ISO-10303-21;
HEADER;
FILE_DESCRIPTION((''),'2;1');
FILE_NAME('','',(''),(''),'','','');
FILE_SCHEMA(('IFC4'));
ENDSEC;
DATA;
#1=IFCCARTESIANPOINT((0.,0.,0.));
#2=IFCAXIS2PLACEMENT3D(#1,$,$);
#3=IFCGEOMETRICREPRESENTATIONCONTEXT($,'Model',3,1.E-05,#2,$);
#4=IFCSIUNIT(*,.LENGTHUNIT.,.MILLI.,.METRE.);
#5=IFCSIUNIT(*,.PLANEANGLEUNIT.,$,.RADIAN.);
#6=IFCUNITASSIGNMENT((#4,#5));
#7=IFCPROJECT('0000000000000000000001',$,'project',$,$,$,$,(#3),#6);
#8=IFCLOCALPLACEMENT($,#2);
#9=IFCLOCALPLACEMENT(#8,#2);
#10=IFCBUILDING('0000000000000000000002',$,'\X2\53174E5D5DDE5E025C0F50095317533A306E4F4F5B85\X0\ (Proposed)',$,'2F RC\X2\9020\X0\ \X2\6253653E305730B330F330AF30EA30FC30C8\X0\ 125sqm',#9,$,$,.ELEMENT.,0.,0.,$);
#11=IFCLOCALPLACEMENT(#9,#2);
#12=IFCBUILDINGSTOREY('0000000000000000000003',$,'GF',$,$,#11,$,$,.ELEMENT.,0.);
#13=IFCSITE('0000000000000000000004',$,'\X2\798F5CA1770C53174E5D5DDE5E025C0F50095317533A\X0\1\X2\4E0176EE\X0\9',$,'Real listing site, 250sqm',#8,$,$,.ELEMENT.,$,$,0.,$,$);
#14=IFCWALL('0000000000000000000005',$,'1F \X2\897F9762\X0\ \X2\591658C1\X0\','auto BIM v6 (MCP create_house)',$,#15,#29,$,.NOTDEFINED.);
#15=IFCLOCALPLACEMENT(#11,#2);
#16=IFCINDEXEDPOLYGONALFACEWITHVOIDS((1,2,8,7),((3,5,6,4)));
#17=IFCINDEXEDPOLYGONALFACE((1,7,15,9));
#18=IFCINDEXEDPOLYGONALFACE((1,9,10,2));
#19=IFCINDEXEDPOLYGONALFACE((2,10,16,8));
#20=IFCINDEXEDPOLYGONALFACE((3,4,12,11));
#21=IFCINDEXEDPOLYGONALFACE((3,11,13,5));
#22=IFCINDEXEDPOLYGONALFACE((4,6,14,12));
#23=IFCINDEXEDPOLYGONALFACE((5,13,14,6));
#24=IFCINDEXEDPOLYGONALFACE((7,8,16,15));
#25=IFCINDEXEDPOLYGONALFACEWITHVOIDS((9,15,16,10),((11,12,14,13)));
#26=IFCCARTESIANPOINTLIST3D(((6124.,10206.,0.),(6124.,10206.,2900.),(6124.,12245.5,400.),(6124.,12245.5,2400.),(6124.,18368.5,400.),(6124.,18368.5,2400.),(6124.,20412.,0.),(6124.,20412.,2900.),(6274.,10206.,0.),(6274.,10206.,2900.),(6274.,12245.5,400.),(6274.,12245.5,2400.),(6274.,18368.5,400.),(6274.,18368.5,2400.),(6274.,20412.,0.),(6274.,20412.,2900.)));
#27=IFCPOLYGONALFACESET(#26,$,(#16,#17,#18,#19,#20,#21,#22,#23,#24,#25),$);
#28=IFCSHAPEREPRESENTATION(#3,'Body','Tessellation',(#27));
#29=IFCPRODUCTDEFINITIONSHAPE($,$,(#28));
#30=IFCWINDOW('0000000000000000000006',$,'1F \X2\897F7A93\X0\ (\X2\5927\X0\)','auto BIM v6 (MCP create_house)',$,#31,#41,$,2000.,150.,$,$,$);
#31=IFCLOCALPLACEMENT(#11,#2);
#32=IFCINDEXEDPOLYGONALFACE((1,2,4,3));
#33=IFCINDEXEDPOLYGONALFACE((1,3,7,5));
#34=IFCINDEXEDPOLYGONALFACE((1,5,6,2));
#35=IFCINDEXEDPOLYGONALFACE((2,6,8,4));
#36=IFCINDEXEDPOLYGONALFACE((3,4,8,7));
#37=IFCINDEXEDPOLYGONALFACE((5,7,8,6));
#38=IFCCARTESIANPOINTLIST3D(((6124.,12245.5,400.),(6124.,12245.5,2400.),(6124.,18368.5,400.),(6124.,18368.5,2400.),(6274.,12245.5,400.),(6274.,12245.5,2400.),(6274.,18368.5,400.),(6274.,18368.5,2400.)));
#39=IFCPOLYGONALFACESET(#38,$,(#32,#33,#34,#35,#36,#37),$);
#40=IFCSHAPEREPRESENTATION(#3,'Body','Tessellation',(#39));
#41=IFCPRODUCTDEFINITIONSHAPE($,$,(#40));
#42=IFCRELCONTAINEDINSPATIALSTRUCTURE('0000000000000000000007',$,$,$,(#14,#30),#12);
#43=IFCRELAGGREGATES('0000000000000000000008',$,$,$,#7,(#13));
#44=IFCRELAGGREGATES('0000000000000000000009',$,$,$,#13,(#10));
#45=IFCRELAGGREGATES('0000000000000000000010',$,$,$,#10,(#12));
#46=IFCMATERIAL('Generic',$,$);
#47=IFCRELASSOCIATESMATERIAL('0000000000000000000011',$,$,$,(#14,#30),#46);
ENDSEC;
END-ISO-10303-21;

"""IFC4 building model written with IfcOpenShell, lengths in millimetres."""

from ifc_helpers import new_model, si_unit, frame, frame_2d, origin, place, context, project, spatial, rectangle, extrude, material, element, fill, save


model = new_model("IFC4")

# Units and contexts
model_context = context("Model", 3, precision=1e-05, world=origin())
ifc_project = project(units=[si_unit("LENGTHUNIT", "METRE", prefix="MILLI"), si_unit("PLANEANGLEUNIT", "RADIAN")], contexts=[model_context])

# Site, building, storey
site_placement = place(None, origin())
site = spatial("IfcSite", under=ifc_project, at=site_placement, Name="福岡県北九州市小倉北区1丁目9", ObjectType="Real listing site, 250sqm", CompositionType="ELEMENT", RefElevation=0.0)
building_placement = place(site_placement, origin())
building = spatial("IfcBuilding", under=site, at=building_placement, Name="北九州市小倉北区の住宅 (Proposed)", ObjectType="2F RC造 打放しコンクリート 125sqm", CompositionType="ELEMENT", ElevationOfRefHeight=0.0, ElevationOfTerrain=0.0)
storey_placement = place(building_placement, origin())
storey = spatial("IfcBuildingStorey", under=building, at=storey_placement, Name="GF", CompositionType="ELEMENT", Elevation=0.0)

# Shared definitions
ifc_material = material(Name="Generic")

# Wall, opening, window
wall_1_placement = place(storey_placement, frame((3062.0, 5103.0, 0.0)))
wall_1 = element("IfcWall", 1, at=wall_1_placement, inside=storey, material=ifc_material, Name="1F 西面 外壁", Description="auto BIM v6 (MCP create_house)", PredefinedType="NOTDEFINED", context=model_context, shape_type="SweptSolid", body=[
    extrude(rectangle(XDim=150.0, YDim=10206.0, at=frame_2d((75.0, 5103.0))), frame((3062.0, 5103.0, 0.0)), (0.0, 0.0, 1.0), 2900.0),
])
opening_1_placement = place(storey_placement, frame((3062.0, 6123.0, 200.0)))
opening_1 = element("IfcOpeningElement", 2, at=opening_1_placement, cuts=wall_1, PredefinedType="NOTDEFINED", context=model_context, shape_type="SweptSolid", body=[
    extrude(rectangle(XDim=150.0, YDim=6123.0, at=frame_2d((75.0, 3061.0))), frame((3062.0, 6123.0, 200.0)), (0.0, 0.0, 1.0), 2000.0),
])
window_1_placement = place(storey_placement, frame((3062.0, 6123.0, 200.0)))
window_1 = element("IfcWindow", 3, at=window_1_placement, inside=storey, material=ifc_material, Name="1F 西窓 (大)", Description="auto BIM v6 (MCP create_house)", OverallHeight=2000.0, OverallWidth=150.0, context=model_context, shape_type="SweptSolid", body=[
    extrude(rectangle(XDim=150.0, YDim=6123.0, at=frame_2d((75.0, 3061.0))), frame((3062.0, 6123.0, 200.0)), (0.0, 0.0, 1.0), 2000.0),
])
fill(opening_1, window_1)

save(model, "model.ifc")
